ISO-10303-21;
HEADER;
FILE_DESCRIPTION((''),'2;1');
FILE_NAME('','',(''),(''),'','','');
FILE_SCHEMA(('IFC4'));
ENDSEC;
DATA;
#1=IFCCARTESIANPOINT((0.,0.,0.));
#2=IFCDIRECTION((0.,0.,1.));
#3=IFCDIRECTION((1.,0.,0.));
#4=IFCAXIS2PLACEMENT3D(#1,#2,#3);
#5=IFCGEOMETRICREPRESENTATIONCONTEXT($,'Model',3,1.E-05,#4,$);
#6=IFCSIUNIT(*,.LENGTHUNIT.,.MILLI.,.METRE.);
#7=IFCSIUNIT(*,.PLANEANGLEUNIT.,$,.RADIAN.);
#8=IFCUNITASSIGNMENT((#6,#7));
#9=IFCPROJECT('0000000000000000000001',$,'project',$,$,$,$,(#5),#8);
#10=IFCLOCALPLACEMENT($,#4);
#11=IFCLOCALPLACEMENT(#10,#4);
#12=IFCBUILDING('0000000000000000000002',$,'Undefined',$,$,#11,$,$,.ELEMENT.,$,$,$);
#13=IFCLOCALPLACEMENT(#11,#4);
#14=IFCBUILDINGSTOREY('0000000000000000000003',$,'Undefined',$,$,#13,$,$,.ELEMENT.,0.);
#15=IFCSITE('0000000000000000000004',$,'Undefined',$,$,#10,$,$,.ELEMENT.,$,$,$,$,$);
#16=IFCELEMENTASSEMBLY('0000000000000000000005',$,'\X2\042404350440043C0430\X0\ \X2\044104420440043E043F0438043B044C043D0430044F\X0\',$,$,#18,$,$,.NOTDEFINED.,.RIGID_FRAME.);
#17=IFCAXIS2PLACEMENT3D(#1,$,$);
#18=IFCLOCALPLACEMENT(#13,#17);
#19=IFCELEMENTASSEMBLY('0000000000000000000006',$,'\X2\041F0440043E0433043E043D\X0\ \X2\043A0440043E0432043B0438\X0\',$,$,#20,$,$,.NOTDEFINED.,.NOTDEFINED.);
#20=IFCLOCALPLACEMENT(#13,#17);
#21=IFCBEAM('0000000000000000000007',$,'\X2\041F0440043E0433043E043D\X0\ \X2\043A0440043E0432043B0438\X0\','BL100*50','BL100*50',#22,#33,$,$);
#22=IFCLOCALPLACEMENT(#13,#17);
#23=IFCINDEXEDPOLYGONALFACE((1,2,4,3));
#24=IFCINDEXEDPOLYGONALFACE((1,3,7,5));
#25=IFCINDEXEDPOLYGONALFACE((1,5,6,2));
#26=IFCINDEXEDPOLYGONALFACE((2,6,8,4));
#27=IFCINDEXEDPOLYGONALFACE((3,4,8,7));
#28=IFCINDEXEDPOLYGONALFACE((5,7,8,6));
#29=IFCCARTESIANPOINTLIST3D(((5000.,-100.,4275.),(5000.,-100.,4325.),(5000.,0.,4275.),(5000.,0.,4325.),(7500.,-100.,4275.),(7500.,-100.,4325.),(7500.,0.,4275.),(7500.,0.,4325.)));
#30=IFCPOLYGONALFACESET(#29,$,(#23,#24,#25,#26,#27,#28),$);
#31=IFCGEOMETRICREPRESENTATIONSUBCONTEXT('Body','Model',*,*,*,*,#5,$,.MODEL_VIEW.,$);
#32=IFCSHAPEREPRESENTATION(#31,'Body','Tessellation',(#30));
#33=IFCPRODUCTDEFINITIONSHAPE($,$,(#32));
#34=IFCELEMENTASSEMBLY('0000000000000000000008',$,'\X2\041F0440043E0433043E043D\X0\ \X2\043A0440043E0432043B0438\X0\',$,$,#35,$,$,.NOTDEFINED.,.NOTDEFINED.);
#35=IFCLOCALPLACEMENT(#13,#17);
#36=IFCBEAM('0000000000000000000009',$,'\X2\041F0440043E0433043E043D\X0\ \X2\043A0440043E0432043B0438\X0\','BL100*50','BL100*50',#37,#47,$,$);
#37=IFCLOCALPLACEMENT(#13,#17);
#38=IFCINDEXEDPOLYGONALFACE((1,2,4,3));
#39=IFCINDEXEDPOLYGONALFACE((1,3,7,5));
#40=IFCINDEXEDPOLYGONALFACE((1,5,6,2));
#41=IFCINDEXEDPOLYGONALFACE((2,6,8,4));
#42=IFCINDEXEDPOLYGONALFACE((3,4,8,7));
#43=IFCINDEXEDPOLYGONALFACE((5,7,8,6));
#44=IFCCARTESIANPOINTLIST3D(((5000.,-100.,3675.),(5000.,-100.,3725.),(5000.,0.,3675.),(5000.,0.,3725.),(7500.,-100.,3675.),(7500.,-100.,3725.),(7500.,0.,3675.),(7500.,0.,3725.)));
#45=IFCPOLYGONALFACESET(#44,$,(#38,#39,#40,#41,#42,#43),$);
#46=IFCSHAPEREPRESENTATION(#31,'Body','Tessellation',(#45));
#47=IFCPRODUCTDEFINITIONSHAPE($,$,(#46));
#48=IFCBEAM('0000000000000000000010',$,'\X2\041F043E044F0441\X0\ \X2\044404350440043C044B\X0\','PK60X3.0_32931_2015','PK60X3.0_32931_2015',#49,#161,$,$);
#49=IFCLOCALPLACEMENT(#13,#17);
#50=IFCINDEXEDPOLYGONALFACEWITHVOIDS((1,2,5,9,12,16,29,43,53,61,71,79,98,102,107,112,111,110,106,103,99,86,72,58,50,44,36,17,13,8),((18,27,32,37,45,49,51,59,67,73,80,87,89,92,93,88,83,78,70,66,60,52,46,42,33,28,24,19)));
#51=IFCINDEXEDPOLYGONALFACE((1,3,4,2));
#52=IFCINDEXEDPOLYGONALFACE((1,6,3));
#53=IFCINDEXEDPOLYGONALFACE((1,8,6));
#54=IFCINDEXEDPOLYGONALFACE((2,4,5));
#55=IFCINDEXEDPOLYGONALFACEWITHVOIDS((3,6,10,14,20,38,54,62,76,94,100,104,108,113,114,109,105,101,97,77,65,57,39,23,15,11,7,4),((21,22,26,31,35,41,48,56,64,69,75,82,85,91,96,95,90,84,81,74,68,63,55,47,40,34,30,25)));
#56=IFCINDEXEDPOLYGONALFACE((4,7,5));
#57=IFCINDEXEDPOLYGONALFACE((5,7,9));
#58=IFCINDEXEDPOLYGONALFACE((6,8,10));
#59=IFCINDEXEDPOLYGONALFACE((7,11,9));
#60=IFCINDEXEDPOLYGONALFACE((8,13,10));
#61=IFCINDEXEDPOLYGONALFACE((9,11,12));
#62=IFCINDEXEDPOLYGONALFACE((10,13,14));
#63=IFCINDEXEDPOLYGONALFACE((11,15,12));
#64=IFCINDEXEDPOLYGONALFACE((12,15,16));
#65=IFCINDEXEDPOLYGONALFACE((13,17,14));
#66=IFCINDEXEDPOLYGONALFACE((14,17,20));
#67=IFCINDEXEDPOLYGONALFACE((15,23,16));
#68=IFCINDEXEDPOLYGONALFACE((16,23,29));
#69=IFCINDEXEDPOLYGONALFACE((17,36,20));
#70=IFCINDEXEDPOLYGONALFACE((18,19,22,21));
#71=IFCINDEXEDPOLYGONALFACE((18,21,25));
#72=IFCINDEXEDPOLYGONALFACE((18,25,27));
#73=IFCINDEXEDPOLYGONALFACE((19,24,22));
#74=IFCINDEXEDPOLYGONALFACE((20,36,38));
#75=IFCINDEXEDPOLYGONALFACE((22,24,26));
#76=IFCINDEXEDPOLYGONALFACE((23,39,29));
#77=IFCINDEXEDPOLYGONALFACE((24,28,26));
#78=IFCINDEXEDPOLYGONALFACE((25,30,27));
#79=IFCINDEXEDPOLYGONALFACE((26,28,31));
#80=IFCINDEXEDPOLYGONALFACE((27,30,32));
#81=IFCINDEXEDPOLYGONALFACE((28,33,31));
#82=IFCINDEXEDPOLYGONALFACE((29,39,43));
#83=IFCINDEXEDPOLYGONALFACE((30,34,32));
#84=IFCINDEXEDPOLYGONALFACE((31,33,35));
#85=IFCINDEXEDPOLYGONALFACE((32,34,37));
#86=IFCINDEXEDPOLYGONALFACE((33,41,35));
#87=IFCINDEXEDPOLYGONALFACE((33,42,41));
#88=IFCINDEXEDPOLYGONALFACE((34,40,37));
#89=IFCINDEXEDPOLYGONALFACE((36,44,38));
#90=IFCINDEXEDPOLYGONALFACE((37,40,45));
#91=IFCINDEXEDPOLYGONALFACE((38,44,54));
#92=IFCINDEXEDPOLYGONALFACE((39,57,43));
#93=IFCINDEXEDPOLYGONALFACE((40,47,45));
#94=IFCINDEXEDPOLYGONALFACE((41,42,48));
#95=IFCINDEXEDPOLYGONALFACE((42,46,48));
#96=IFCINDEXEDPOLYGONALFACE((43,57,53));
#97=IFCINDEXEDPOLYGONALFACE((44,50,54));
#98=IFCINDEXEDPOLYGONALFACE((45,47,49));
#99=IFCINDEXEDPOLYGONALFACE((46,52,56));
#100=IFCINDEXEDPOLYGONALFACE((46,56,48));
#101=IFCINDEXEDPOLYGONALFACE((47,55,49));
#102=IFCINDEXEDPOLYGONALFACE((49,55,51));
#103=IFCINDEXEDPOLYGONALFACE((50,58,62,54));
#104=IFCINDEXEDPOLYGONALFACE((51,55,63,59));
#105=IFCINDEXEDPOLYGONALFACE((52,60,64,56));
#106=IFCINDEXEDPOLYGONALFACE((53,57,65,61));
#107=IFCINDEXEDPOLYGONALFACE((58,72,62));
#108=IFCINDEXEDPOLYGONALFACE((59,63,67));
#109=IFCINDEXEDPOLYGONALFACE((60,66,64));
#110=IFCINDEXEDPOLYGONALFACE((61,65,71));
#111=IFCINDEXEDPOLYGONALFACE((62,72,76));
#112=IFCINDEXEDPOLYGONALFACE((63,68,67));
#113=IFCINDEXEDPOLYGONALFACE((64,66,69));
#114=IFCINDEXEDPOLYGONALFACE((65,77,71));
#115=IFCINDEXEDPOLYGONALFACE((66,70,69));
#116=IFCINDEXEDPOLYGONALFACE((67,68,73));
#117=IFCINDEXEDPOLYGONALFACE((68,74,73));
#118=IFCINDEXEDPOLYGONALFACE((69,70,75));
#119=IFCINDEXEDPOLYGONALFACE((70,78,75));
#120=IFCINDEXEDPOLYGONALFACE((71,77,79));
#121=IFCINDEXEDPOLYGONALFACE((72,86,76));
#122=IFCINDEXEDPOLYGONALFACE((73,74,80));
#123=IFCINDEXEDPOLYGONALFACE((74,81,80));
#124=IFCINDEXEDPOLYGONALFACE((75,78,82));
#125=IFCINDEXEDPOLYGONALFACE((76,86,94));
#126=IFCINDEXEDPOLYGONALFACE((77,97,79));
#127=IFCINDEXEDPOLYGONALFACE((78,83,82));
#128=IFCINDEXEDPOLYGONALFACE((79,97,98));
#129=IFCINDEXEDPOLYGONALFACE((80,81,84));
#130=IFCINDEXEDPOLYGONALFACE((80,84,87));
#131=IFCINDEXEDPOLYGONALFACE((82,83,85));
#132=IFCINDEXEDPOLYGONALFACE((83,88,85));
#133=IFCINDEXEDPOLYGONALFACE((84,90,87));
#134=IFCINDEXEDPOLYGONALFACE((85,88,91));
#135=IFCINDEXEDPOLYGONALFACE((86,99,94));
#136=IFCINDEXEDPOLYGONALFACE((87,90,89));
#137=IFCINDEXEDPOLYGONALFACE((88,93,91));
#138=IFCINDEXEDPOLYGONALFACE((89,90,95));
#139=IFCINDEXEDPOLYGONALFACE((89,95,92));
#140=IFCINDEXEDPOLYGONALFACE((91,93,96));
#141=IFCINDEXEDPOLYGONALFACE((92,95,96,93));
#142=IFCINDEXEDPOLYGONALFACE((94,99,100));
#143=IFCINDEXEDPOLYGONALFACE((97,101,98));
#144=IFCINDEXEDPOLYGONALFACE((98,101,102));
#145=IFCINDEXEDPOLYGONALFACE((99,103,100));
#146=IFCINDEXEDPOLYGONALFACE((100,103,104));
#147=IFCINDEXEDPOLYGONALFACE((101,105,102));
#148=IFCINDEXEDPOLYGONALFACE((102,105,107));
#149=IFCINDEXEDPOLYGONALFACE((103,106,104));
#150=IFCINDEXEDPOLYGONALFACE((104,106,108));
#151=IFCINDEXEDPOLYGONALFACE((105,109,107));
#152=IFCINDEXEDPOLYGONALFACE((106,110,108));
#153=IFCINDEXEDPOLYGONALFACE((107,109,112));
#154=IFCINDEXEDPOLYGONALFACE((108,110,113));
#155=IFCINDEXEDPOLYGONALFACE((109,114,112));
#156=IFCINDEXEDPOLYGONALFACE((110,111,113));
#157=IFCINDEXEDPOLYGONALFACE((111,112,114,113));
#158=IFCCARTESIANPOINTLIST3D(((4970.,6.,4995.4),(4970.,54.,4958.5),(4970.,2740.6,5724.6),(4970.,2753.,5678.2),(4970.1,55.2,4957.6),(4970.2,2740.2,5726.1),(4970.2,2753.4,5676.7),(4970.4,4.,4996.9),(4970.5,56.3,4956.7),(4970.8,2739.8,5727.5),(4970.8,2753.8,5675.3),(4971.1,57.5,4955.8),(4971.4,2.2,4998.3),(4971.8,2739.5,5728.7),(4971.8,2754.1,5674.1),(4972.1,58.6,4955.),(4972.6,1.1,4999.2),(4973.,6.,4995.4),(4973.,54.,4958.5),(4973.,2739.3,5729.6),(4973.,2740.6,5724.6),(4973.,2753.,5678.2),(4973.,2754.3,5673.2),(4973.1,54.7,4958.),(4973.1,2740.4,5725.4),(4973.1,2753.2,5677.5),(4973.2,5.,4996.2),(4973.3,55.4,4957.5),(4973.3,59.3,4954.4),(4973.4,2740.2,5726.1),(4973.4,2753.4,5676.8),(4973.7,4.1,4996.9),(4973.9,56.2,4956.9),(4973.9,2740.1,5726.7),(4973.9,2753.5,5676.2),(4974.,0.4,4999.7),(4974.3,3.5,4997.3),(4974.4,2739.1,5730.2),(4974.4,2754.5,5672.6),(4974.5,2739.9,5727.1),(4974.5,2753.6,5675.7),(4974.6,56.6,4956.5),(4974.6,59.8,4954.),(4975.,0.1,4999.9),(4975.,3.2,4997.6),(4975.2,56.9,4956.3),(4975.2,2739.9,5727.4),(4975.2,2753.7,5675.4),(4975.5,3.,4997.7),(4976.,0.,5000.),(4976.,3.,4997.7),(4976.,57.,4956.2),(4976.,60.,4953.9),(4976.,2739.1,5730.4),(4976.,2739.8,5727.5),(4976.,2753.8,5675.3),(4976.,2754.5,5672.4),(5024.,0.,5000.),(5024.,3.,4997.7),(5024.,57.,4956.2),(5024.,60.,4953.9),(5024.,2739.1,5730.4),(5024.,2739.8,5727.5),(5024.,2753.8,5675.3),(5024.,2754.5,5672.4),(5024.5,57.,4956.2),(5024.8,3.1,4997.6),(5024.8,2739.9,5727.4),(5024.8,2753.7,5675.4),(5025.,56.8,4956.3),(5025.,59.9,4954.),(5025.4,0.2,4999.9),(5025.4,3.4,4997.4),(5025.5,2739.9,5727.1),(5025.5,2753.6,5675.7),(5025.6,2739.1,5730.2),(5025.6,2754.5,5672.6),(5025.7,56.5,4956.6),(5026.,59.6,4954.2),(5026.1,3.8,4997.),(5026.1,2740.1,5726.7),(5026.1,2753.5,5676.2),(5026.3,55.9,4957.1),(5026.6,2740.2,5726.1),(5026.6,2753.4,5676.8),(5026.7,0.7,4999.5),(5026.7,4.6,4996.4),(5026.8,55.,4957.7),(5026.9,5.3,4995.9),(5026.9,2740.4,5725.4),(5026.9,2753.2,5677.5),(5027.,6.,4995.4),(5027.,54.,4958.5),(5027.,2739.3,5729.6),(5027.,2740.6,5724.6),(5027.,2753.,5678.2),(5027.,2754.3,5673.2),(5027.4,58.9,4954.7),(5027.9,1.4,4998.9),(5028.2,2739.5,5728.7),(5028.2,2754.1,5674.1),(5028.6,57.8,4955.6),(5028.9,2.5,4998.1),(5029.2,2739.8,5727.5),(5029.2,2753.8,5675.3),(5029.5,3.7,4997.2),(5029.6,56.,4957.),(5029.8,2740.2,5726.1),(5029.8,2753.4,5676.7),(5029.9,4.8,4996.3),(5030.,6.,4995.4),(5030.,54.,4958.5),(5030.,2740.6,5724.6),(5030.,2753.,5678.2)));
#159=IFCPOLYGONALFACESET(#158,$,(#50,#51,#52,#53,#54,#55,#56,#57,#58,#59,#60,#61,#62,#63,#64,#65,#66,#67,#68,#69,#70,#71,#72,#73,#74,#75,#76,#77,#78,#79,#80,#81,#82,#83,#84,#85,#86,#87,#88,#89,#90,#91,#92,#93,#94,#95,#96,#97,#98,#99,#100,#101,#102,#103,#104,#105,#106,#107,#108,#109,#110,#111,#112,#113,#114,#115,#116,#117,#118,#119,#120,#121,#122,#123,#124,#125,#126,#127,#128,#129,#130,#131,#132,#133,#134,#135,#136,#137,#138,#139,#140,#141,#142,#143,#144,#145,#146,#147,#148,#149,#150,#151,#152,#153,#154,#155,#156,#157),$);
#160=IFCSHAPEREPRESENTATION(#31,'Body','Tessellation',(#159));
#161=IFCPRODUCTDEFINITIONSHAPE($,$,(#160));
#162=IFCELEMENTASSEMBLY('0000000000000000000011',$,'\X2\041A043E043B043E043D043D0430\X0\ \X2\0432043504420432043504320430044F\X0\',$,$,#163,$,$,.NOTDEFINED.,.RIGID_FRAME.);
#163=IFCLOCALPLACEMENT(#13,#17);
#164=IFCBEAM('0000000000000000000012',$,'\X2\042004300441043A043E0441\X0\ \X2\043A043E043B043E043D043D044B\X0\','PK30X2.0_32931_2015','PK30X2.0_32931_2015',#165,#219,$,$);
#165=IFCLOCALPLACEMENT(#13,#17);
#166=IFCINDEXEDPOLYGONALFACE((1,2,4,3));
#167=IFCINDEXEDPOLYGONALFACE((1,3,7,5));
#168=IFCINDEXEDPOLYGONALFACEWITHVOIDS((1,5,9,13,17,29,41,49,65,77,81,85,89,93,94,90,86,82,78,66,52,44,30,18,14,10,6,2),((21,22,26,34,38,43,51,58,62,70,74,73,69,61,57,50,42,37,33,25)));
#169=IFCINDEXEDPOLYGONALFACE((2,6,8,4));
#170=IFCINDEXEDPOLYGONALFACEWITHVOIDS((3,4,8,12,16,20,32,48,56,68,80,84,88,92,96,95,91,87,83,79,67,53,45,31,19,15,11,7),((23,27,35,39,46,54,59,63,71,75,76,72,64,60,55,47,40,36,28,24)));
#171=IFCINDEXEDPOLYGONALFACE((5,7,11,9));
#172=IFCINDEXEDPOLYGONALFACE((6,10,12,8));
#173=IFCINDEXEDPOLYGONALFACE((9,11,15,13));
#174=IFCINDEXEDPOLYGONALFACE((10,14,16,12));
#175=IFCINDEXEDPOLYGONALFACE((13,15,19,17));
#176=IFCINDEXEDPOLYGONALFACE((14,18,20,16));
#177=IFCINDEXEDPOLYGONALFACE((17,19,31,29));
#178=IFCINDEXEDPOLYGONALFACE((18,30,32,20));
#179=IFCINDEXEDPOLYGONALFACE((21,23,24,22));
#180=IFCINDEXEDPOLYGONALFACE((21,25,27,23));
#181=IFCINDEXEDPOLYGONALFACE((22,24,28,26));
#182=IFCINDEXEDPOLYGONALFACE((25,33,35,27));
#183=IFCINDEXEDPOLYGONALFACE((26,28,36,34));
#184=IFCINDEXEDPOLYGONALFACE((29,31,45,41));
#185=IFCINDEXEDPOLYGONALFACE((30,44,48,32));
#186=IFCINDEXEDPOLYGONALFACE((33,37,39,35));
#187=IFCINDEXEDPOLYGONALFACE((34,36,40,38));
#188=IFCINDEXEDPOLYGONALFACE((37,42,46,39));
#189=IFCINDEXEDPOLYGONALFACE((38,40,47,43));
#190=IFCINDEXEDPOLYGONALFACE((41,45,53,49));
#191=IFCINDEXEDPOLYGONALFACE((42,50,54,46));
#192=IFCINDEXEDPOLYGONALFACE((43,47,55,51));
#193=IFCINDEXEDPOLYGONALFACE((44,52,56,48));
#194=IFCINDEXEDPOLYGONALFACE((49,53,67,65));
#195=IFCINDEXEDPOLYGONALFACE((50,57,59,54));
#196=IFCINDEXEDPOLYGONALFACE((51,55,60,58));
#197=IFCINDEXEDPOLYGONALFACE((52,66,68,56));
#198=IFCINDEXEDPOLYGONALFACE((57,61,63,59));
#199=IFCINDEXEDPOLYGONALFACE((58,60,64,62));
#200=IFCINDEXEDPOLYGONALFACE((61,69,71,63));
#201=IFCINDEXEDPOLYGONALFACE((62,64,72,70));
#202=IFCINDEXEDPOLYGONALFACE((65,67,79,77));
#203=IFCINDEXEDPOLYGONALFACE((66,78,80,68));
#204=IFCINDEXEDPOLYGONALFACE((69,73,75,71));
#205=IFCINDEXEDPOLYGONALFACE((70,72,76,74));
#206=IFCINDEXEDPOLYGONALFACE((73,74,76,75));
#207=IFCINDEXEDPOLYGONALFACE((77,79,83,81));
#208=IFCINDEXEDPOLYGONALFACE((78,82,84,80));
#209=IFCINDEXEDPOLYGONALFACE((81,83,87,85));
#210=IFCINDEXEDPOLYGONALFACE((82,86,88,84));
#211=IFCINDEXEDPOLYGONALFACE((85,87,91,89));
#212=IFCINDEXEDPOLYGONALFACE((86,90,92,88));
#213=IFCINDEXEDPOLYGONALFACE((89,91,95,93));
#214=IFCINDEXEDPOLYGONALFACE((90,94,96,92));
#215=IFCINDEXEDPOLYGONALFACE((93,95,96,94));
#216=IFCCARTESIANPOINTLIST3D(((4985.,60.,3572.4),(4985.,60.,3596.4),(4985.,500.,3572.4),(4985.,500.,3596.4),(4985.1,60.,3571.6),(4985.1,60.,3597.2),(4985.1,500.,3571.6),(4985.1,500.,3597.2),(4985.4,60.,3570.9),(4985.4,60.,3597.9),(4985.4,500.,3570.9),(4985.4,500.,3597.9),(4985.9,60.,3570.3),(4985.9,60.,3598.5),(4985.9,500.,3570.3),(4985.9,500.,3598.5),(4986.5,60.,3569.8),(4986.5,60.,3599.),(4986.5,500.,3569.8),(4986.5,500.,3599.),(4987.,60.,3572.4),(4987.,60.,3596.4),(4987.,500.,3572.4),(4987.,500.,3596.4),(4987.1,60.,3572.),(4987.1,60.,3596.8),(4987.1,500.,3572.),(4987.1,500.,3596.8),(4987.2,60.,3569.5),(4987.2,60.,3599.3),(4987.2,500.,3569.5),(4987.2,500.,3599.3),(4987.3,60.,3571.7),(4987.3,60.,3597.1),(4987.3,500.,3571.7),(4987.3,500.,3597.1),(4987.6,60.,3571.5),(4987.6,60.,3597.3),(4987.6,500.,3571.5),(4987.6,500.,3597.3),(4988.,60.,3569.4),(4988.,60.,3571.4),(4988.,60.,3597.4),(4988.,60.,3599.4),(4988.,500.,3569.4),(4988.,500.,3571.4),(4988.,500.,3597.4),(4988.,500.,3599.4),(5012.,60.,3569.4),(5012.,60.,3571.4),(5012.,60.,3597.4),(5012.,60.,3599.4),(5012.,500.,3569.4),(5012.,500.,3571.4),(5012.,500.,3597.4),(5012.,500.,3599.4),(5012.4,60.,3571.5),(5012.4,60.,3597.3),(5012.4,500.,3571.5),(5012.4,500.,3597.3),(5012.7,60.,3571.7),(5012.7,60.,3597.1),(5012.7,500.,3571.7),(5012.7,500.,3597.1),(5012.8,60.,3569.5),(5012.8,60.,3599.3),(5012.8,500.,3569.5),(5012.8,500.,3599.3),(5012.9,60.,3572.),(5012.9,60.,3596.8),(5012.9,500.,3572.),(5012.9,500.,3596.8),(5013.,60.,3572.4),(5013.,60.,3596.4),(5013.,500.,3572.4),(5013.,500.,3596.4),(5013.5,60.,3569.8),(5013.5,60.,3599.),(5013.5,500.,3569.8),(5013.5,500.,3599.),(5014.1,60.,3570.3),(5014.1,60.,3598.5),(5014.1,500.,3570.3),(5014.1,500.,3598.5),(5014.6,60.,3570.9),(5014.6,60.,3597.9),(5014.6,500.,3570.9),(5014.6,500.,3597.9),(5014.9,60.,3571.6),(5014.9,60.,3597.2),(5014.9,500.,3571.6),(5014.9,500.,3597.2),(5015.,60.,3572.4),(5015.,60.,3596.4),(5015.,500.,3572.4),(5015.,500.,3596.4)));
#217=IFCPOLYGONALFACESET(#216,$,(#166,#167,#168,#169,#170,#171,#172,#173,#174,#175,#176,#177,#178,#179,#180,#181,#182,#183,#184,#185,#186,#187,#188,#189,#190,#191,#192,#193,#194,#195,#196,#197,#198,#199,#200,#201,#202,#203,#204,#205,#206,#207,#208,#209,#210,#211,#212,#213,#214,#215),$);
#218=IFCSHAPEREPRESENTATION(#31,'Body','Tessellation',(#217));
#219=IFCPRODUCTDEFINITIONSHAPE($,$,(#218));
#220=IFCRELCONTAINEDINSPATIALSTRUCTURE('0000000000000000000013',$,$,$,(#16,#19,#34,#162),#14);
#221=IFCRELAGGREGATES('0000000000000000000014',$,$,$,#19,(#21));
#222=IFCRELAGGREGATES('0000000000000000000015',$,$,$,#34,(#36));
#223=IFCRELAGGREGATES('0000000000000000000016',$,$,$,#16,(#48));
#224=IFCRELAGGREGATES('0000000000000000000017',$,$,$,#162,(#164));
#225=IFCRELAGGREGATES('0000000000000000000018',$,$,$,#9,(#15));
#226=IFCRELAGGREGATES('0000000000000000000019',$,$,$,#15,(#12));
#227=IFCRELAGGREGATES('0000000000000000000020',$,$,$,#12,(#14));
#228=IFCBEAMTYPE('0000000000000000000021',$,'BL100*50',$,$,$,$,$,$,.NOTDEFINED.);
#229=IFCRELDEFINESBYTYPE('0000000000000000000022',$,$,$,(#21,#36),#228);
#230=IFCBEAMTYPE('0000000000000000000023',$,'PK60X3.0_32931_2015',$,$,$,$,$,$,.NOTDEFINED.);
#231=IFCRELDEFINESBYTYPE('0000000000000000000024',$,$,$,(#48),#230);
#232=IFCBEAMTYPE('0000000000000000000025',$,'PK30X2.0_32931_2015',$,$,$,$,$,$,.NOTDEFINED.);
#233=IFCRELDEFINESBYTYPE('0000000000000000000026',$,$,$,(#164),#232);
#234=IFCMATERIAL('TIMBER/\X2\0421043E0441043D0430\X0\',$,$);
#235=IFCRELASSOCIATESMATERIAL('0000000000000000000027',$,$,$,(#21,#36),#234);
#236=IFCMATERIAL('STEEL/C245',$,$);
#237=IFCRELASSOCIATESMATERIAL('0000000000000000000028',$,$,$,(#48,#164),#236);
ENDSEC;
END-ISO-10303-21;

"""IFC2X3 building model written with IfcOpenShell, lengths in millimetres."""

from ifc_helpers import new_model, si_unit, frame, origin_with_axes, origin_2d_with_axis, place, context, subcontext, project, spatial, rectangle, hollow_rectangle, extrude, clip, halfspace, material, type_object, element, aggregate, save


model = new_model("IFC2X3")

# Units and contexts
model_context = context("Model", 3, precision=1e-05, world=origin_with_axes())
body_context = subcontext(model_context, "Body", "Model", "MODEL_VIEW")
ifc_project = project(units=[si_unit("LENGTHUNIT", "METRE", prefix="MILLI"), si_unit("PLANEANGLEUNIT", "RADIAN")], contexts=[model_context])

# Site, building, storey
site_placement = place(None, origin_with_axes())
site = spatial("IfcSite", under=ifc_project, at=site_placement, Name="Undefined", CompositionType="ELEMENT")
building_placement = place(site_placement, origin_with_axes())
building = spatial("IfcBuilding", under=site, at=building_placement, Name="Undefined", CompositionType="ELEMENT")
storey_placement = place(building_placement, origin_with_axes())
storey = spatial("IfcBuildingStorey", under=building, at=storey_placement, Name="Undefined", CompositionType="ELEMENT", Elevation=0.0)

# Shared definitions
ifc_material_1 = material(Name="STEEL/C245")

# Element assembly
assembly_1_placement = place(storey_placement, origin_with_axes())
assembly_1 = element("IfcElementAssembly", 1, at=assembly_1_placement, inside=storey, Name="Ферма стропильная", AssemblyPlace="NOTDEFINED", PredefinedType="RIGID_FRAME")

# Element assemblies, beams
ifc_material_2 = material(Name="TIMBER/Сосна")
beam_type_1 = type_object("IfcBeamType", Name="BL100*50", PredefinedType="NOTDEFINED")
assembly_2_placement = place(storey_placement, origin_with_axes())
assembly_2 = element("IfcElementAssembly", 2, at=assembly_2_placement, inside=storey, Name="Прогон кровли", AssemblyPlace="NOTDEFINED", PredefinedType="NOTDEFINED")
beam_1_placement = place(assembly_2_placement, frame((5000.0, -50.0, 4300.0), z_axis=(0.0, -1.0, 0.0), x_axis=(1.0, 0.0, 0.0)))
beam_1 = element("IfcBeam", 3, at=beam_1_placement, type_object=beam_type_1, material=ifc_material_2, Name="Прогон кровли", Description="BL100*50", ObjectType="BL100*50", context=body_context, shape_type="SweptSolid", body=[
    extrude(rectangle(XDim=50.0, YDim=100.0, at=origin_2d_with_axis()), frame((2500.0, 0.0, 0.0), z_axis=(-1.0, 0.0, 0.0), x_axis=(0.0, -1.0, 0.0)), (0.0, 0.0, 1.0), 2500.0),
])
aggregate(assembly_2, [beam_1])
assembly_3_placement = place(storey_placement, origin_with_axes())
assembly_3 = element("IfcElementAssembly", 4, at=assembly_3_placement, inside=storey, Name="Прогон кровли", AssemblyPlace="NOTDEFINED", PredefinedType="NOTDEFINED")
beam_2_placement = place(assembly_3_placement, frame((5000.0, -50.0, 3700.0), z_axis=(0.0, -1.0, 0.0), x_axis=(1.0, 0.0, 0.0)))
beam_2 = element("IfcBeam", 5, at=beam_2_placement, type_object=beam_type_1, material=ifc_material_2, Name="Прогон кровли", Description="BL100*50", ObjectType="BL100*50", context=body_context, shape_type="SweptSolid", body=[
    extrude(rectangle(XDim=50.0, YDim=100.0, at=origin_2d_with_axis()), frame((2500.0, 0.0, 0.0), z_axis=(-1.0, 0.0, 0.0), x_axis=(0.0, -1.0, 0.0)), (0.0, 0.0, 1.0), 2500.0),
])
aggregate(assembly_3, [beam_2])

# Beam
beam_type_2 = type_object("IfcBeamType", Name="PK60X3.0_32931_2015", PredefinedType="NOTDEFINED")
beam_3_placement = place(assembly_1_placement, frame((5000.0, 7.7, 4971.0), z_axis=(0.0, -0.257663, 0.966235), x_axis=(0.0, 0.966235, 0.257663)))
beam_3 = element("IfcBeam", 6, at=beam_3_placement, type_object=beam_type_2, material=ifc_material_1, Name="Пояс фермы", Description="PK60X3.0_32931_2015", ObjectType="PK60X3.0_32931_2015", context=body_context, shape_type="Clipping", body=[
    clip(extrude(hollow_rectangle(XDim=60.0, YDim=60.0, WallThickness=3.0, InnerFilletRadius=3.0, OuterFilletRadius=6.0, at=origin_2d_with_axis()), frame((2834.8, 0.0, 0.0), z_axis=(-1.0, 0.0, 0.0), x_axis=(0.0, -1.0, 0.0)), (0.0, 0.0, 1.0), 2862.1), halfspace(frame((46.1, 0.0, -30.0), z_axis=(0.792989, 0.0, 0.609236), x_axis=(0.0, -1.0, 0.0)), True)),
])
aggregate(assembly_1, [beam_3])

# Element assembly, beam
assembly_4_placement = place(storey_placement, origin_with_axes())
assembly_4 = element("IfcElementAssembly", 7, at=assembly_4_placement, inside=storey, Name="Колонна ветвевая", AssemblyPlace="NOTDEFINED", PredefinedType="RIGID_FRAME")
beam_type_3 = type_object("IfcBeamType", Name="PK30X2.0_32931_2015", PredefinedType="NOTDEFINED")
beam_4_placement = place(assembly_4_placement, frame((5000.0, 500.0, 3584.4), z_axis=(0.0, 0.0, -1.0), x_axis=(0.0, -1.0, 0.0)))
beam_4 = element("IfcBeam", 8, at=beam_4_placement, type_object=beam_type_3, material=ifc_material_1, Name="Раскос колонны", Description="PK30X2.0_32931_2015", ObjectType="PK30X2.0_32931_2015", context=body_context, shape_type="SweptSolid", body=[
    extrude(hollow_rectangle(XDim=30.0, YDim=30.0, WallThickness=2.0, InnerFilletRadius=1.0, OuterFilletRadius=3.0, at=origin_2d_with_axis()), frame((440.0, 0.0, 0.0), z_axis=(-1.0, 0.0, 0.0), x_axis=(0.0, -1.0, 0.0)), (0.0, 0.0, 1.0), 440.0),
])
aggregate(assembly_4, [beam_4])

save(model, "model.ifc")
